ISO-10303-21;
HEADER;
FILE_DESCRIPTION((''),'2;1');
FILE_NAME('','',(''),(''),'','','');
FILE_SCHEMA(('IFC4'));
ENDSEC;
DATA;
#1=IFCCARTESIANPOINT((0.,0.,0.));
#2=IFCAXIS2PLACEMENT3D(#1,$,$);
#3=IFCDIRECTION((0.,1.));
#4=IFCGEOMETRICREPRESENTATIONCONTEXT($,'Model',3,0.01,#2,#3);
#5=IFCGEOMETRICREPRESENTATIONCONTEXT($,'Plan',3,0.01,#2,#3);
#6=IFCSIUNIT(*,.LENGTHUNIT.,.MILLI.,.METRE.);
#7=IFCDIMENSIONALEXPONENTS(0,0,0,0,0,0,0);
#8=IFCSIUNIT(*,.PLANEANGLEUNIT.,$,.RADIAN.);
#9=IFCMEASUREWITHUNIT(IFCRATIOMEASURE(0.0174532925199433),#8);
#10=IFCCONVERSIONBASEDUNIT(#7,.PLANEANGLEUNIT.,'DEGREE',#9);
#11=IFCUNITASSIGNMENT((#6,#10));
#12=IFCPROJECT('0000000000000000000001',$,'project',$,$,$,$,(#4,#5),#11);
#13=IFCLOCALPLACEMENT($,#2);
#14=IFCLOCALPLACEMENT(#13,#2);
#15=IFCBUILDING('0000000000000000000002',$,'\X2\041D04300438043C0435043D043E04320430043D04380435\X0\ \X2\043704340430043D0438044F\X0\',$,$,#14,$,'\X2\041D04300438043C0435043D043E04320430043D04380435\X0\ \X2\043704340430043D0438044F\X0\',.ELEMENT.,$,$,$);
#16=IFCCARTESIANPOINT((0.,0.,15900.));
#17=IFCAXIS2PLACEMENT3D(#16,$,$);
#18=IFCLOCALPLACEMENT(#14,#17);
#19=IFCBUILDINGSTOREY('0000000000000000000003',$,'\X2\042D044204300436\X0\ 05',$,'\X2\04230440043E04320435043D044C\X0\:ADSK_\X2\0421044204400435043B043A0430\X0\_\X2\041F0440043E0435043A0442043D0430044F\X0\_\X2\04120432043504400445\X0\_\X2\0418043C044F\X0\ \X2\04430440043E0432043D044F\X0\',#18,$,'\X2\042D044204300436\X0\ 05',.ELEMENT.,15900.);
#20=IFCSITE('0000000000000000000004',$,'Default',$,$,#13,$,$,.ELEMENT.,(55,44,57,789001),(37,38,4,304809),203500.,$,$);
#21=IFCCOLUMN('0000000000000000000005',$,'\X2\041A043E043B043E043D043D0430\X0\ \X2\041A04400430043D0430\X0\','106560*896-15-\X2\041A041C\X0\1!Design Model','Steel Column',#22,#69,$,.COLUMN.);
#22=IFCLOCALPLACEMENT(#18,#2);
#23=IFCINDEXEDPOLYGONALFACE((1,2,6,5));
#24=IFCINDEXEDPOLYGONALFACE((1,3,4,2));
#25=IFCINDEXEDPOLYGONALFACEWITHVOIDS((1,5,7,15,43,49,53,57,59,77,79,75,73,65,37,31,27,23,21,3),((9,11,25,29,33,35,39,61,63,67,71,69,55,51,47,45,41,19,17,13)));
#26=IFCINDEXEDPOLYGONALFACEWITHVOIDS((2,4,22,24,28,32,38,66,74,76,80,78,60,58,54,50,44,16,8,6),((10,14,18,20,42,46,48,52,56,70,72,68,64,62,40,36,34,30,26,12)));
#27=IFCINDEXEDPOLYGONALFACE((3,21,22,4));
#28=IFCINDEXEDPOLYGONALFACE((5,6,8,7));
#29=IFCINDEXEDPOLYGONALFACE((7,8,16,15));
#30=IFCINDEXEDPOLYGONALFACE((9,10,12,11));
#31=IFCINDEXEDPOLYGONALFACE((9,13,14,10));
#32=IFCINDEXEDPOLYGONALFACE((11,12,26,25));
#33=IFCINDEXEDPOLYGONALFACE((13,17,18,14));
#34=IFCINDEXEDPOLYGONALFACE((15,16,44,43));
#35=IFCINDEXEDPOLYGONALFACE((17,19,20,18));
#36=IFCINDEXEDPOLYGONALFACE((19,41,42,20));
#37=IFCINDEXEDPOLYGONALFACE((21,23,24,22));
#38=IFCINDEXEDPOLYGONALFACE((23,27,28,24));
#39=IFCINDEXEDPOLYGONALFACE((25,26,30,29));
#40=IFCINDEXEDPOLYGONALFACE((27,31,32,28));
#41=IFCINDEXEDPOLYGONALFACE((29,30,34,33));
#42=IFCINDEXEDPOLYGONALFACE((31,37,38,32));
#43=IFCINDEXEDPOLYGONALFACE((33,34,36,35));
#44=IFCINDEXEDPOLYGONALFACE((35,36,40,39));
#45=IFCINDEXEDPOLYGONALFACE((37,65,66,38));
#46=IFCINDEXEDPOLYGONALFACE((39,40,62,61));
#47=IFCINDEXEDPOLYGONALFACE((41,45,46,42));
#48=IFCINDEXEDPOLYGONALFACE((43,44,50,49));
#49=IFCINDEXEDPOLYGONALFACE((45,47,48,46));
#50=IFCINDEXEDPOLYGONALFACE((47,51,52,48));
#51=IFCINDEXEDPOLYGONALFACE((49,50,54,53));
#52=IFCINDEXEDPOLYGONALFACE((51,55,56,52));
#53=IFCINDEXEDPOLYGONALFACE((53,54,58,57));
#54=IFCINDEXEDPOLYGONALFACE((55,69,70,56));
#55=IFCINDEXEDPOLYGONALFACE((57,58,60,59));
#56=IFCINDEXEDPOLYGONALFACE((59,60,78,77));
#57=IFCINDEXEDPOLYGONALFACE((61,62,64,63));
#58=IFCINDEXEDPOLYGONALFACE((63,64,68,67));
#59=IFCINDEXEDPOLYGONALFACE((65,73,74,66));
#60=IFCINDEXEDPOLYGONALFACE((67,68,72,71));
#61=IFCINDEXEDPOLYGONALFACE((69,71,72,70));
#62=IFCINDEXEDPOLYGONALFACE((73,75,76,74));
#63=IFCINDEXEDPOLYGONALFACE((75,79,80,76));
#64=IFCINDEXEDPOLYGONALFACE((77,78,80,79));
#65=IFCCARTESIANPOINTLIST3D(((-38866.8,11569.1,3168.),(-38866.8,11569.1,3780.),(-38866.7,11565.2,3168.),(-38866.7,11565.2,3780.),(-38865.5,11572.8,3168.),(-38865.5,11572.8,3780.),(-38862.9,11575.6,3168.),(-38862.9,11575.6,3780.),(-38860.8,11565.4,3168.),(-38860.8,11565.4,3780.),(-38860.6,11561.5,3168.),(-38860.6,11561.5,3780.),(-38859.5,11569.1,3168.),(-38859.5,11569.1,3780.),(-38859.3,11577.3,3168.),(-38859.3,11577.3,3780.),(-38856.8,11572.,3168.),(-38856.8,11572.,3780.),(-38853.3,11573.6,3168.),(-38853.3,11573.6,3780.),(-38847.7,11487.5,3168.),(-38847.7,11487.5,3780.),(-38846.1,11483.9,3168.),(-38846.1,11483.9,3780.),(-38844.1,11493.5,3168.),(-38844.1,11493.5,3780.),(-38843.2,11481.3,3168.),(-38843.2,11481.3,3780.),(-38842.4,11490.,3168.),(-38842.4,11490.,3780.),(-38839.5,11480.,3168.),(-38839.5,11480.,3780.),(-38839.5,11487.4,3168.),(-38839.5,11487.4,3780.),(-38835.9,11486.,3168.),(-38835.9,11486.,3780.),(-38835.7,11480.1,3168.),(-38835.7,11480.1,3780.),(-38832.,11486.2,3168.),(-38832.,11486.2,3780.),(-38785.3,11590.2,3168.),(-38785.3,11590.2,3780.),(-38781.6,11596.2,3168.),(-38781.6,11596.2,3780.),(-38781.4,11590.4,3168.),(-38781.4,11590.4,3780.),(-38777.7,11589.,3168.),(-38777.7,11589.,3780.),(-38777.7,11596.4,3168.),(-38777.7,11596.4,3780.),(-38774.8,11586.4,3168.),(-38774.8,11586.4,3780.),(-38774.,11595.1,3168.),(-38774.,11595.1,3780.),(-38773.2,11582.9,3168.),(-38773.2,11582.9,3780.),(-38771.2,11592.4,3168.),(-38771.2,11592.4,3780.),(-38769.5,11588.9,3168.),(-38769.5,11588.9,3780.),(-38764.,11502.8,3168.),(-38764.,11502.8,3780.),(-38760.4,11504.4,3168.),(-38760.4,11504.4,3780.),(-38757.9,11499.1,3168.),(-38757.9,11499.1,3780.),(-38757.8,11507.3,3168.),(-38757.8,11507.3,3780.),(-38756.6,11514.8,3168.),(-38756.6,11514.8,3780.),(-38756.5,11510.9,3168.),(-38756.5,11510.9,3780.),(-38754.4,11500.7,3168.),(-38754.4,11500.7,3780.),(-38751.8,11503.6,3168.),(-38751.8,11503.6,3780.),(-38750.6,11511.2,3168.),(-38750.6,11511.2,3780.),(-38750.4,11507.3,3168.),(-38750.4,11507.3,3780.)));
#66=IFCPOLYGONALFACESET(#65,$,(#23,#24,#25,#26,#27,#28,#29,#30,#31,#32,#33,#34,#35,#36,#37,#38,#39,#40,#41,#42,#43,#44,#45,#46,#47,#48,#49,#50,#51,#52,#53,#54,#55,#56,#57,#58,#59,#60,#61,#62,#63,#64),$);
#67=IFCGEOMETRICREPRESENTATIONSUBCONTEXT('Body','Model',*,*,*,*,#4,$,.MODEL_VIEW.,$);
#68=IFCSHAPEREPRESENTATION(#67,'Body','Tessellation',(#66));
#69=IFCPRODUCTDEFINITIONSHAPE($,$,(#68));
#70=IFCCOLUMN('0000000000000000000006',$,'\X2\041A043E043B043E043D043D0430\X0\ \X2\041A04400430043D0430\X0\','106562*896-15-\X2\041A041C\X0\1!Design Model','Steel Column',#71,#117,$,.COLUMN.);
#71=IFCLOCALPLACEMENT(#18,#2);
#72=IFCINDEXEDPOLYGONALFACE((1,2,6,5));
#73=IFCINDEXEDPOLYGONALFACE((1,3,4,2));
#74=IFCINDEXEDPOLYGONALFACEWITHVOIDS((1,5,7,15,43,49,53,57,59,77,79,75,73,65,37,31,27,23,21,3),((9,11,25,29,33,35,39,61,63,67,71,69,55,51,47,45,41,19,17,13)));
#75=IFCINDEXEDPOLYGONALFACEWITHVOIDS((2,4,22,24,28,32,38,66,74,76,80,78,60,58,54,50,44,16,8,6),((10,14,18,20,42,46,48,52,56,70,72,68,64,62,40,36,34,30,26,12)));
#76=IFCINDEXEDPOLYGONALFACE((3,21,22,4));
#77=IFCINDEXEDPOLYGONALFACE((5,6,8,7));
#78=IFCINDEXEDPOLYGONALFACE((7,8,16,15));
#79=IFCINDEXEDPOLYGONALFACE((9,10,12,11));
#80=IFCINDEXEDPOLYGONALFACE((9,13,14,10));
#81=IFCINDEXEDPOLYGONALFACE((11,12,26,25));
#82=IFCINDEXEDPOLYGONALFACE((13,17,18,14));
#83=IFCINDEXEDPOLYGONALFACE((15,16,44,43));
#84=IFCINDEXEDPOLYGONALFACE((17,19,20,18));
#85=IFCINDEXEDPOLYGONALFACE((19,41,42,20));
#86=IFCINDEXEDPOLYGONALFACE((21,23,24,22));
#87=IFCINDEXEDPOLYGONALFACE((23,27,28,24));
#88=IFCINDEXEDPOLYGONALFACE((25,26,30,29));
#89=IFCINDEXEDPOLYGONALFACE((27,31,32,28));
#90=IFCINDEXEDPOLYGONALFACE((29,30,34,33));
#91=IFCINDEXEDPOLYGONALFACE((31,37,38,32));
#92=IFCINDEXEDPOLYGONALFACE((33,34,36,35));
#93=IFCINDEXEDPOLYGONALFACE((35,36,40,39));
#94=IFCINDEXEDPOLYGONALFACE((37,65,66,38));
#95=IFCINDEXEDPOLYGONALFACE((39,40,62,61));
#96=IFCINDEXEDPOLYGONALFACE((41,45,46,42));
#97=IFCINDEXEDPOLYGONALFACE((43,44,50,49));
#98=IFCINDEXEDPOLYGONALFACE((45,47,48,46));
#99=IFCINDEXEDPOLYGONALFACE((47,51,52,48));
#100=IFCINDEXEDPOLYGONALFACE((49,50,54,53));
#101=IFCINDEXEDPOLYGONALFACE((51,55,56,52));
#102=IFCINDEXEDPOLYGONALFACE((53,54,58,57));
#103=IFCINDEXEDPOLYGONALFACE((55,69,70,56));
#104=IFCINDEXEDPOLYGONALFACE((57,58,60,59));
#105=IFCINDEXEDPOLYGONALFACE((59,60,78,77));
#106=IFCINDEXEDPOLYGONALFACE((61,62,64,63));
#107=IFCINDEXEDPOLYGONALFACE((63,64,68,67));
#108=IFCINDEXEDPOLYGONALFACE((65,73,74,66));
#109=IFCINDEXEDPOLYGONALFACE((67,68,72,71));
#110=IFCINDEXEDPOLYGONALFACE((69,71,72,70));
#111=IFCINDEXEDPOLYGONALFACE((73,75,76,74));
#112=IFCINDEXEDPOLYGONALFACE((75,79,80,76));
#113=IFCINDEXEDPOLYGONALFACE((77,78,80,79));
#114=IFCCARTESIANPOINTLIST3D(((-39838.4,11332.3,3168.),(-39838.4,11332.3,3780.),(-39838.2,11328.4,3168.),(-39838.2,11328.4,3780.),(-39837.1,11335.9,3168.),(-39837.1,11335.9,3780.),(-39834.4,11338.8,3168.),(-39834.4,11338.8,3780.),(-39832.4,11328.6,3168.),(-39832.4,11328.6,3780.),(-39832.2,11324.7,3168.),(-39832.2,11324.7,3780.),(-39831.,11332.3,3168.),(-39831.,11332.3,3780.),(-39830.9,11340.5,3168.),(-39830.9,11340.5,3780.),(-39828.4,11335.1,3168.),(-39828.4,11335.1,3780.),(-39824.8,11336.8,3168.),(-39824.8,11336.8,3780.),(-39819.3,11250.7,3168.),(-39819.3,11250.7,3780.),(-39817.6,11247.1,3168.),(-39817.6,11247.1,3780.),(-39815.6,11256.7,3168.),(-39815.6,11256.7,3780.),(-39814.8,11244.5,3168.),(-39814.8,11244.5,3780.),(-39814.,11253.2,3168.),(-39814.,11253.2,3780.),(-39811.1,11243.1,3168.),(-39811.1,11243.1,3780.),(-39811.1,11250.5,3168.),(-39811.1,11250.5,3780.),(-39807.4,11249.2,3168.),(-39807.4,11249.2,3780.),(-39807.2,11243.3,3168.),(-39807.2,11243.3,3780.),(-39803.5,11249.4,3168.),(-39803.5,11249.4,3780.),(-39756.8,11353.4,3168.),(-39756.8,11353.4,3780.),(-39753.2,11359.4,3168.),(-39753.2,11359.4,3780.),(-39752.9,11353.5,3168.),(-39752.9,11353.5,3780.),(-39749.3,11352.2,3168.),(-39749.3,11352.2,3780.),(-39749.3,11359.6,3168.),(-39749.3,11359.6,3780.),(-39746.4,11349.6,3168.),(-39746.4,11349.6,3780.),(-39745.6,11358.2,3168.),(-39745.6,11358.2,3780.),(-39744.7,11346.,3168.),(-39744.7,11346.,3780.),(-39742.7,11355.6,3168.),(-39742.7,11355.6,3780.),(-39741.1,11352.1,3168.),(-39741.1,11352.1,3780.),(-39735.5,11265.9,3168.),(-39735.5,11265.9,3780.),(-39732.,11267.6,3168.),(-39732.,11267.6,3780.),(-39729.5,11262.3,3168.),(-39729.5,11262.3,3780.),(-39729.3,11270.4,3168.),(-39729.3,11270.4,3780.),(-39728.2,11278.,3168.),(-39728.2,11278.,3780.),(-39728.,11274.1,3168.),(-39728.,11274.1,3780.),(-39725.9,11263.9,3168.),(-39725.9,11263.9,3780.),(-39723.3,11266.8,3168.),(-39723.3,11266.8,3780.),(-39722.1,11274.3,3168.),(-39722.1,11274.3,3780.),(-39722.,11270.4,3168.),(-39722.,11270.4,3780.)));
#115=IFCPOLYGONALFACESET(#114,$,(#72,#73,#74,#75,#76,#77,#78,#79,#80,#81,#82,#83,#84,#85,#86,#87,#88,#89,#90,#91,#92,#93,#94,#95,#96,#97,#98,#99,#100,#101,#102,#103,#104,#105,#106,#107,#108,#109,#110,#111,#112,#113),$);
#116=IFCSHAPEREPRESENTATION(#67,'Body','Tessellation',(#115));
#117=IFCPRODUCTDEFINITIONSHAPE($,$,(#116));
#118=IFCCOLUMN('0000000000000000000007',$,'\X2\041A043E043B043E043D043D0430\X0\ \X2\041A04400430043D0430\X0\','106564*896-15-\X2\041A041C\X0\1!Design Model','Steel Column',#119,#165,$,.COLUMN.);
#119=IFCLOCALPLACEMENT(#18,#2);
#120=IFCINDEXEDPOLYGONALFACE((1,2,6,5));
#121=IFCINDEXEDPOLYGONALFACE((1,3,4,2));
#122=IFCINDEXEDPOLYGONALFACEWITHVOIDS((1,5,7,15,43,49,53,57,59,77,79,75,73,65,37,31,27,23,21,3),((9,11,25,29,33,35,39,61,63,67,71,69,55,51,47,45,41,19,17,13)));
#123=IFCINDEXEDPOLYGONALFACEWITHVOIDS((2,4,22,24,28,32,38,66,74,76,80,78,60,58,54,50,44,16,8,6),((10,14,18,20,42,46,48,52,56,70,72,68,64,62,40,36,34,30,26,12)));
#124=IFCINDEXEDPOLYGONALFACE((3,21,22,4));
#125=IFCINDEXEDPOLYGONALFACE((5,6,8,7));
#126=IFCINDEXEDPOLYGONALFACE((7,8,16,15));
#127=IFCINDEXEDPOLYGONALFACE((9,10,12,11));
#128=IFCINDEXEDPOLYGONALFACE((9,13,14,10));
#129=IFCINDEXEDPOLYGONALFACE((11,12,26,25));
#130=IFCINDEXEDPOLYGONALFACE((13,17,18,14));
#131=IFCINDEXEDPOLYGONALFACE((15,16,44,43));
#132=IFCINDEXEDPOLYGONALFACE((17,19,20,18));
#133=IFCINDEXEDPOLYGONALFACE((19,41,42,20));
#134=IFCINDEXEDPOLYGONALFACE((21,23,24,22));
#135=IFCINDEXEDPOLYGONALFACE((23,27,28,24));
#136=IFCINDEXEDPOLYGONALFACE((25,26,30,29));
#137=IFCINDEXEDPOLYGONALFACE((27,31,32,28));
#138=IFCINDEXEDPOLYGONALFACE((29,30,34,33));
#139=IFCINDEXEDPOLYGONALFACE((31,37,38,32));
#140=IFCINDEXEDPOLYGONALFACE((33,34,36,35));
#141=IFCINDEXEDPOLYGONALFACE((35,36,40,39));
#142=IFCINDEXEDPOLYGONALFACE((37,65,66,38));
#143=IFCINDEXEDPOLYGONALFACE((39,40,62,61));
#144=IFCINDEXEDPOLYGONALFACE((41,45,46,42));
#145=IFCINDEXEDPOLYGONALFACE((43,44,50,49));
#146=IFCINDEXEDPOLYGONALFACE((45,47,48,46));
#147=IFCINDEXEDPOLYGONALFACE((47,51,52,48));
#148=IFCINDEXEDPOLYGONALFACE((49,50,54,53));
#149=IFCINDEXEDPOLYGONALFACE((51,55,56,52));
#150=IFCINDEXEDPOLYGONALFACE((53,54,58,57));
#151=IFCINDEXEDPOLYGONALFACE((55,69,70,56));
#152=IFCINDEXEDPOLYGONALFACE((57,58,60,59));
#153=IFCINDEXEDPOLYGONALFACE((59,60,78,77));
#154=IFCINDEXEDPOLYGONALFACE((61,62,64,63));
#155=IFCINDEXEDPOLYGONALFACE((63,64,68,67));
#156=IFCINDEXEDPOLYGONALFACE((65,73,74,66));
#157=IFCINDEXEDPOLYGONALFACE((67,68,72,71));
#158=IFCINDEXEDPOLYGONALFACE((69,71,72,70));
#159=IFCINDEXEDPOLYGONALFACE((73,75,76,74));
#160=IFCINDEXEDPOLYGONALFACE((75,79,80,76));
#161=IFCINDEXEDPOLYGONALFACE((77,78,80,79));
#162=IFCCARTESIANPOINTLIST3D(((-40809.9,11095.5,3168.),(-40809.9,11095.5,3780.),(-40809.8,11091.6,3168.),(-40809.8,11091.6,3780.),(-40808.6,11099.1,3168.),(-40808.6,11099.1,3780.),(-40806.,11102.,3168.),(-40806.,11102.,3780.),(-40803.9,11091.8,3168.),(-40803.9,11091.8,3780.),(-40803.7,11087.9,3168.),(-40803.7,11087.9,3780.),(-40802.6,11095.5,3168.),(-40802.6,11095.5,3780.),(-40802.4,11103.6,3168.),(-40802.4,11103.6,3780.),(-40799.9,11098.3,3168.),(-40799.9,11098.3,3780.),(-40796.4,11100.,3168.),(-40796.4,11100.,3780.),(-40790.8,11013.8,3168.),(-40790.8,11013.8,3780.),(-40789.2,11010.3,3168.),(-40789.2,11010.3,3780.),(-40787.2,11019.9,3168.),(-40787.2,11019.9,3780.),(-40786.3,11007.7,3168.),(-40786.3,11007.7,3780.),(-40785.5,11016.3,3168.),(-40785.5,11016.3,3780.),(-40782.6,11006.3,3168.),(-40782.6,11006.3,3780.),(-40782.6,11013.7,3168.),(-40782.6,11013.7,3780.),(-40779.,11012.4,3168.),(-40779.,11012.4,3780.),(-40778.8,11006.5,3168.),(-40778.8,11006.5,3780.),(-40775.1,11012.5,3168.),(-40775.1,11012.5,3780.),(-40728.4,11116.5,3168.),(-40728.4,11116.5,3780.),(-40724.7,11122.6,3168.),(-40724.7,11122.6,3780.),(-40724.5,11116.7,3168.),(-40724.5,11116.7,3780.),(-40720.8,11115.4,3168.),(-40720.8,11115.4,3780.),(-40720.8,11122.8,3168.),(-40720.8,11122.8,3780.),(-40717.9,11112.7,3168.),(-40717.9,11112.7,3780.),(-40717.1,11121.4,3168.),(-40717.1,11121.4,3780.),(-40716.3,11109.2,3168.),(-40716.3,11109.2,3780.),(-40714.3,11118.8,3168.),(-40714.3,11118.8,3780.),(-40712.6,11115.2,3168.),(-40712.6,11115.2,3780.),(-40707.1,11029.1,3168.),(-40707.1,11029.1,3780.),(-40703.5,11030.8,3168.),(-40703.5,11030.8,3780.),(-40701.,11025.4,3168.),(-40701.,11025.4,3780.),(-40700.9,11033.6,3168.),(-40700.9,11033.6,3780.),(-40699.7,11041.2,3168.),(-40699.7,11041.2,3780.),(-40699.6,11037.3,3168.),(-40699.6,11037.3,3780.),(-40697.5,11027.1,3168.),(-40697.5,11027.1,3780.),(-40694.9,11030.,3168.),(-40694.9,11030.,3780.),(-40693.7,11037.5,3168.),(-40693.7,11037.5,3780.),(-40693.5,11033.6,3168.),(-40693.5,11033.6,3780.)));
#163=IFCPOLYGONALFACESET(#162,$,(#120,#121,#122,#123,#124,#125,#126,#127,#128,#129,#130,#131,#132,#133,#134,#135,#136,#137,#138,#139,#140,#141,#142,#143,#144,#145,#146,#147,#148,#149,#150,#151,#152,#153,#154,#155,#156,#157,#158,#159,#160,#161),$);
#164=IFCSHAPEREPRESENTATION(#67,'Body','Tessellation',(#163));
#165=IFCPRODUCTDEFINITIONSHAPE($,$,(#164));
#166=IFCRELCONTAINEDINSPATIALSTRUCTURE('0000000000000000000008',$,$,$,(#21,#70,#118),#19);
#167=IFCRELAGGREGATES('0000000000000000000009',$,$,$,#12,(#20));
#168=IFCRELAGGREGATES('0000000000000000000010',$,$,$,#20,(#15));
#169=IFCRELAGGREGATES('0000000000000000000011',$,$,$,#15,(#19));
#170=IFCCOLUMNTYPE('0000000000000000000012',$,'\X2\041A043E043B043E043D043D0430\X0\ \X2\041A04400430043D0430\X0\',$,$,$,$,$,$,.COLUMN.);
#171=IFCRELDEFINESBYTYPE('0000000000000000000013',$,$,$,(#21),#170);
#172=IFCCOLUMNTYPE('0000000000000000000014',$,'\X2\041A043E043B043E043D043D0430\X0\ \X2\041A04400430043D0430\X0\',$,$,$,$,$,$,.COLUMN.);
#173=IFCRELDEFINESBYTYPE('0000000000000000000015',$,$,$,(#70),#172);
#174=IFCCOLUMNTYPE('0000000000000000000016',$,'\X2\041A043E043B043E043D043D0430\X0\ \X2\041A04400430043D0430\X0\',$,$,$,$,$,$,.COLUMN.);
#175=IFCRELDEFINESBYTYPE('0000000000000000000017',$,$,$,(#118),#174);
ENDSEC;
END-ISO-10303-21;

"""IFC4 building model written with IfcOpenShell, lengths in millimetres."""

from ifc_helpers import new_model, entity, si_unit, converted_unit, direction, frame, origin, place, context, subcontext, project, spatial, indexed_curve, outline, extrude, type_object, element, save


model = new_model("IFC4")

# Units and contexts
model_context = context("Model", 3, precision=0.01, world=origin(), true_north=direction((0.0, 1.0)))
plan_context = context("Plan", 3, precision=0.01, world=origin(), true_north=direction((0.0, 1.0)))
body_context = subcontext(model_context, "Body", "Model", "MODEL_VIEW")
ifc_project = project(units=[si_unit("LENGTHUNIT", "METRE", prefix="MILLI"), converted_unit("PLANEANGLEUNIT", "DEGREE", entity("IfcRatioMeasure", 0.0174532925199433), si_unit("PLANEANGLEUNIT", "RADIAN"), dimensions=[0, 0, 0, 0, 0, 0, 0])], contexts=[model_context, plan_context])

# Site, building, storey
site_placement = place(None, origin())
site = spatial("IfcSite", under=ifc_project, at=site_placement, Name="Default", CompositionType="ELEMENT", RefLatitude=(55, 44, 57, 789001), RefLongitude=(37, 38, 4, 304809), RefElevation=203500.0)
building_placement = place(site_placement, origin())
building = spatial("IfcBuilding", under=site, at=building_placement, Name="Наименование здания", LongName="Наименование здания", CompositionType="ELEMENT")
storey_placement = place(building_placement, frame((0.0, 0.0, 15900.0)))
storey = spatial("IfcBuildingStorey", under=building, at=storey_placement, Name="Этаж 05", ObjectType="Уровень:ADSK_Стрелка_Проектная_Вверх_Имя уровня", LongName="Этаж 05", CompositionType="ELEMENT", Elevation=15900.0)

# Columns
placement = place(storey_placement, origin())
column_type_1 = type_object("IfcColumnType", Name="Колонна Крана", PredefinedType="COLUMN")
element("IfcColumn", 1, at=placement, inside=storey, type_object=column_type_1, Name="Колонна Крана", Description="106560*896-15-КМ1!Design Model", ObjectType="Steel Column", PredefinedType="COLUMN", context=body_context, shape_type="SweptSolid", body=[
    extrude(outline(indexed_curve([(29.5, -56.8), (33.4, -56.8), (37.0, -55.3), (39.7, -52.6), (41.2, -49.0), (56.8, 29.5), (56.8, 33.4), (55.3, 37.0), (52.6, 39.7), (49.0, 41.2), (-29.5, 56.8), (-33.4, 56.8), (-37.0, 55.3), (-39.7, 52.6), (-41.2, 49.0), (-56.8, -29.5), (-56.8, -33.4), (-55.3, -37.0), (-52.6, -39.7), (-49.0, -41.2), (29.5, -56.8)], self_intersect=False), holes=[indexed_curve([(-43.1, -37.3), (-46.7, -35.8), (-49.5, -33.1), (-51.0, -29.5), (-51.0, -25.5), (-37.3, 43.1), (-35.8, 46.7), (-33.1, 49.5), (-29.5, 51.0), (-25.5, 51.0), (43.1, 37.3), (46.7, 35.8), (49.5, 33.1), (51.0, 29.5), (51.0, 25.5), (37.3, -43.1), (35.8, -46.7), (33.1, -49.5), (29.5, -51.0), (25.5, -51.0), (-43.1, -37.3)], self_intersect=False)]), frame((-38808.6, 11538.2, 3168.0), z_axis=(0.0, 0.0, 1.0), x_axis=(0.906681, 0.421816, 0.0)), (0.0, 0.0, 1.0), 612.0),
])
column_type_2 = type_object("IfcColumnType", Name="Колонна Крана", PredefinedType="COLUMN")
element("IfcColumn", 2, at=placement, inside=storey, type_object=column_type_2, Name="Колонна Крана", Description="106562*896-15-КМ1!Design Model", ObjectType="Steel Column", PredefinedType="COLUMN", context=body_context, shape_type="SweptSolid", body=[
    extrude(outline(indexed_curve([(29.5, -56.8), (33.4, -56.8), (37.0, -55.3), (39.7, -52.6), (41.2, -49.0), (56.8, 29.5), (56.8, 33.4), (55.3, 37.0), (52.6, 39.7), (49.0, 41.2), (-29.5, 56.8), (-33.4, 56.8), (-37.0, 55.3), (-39.7, 52.6), (-41.2, 49.0), (-56.8, -29.5), (-56.8, -33.4), (-55.3, -37.0), (-52.6, -39.7), (-49.0, -41.2), (29.5, -56.8)], self_intersect=False), holes=[indexed_curve([(-43.1, -37.3), (-46.7, -35.8), (-49.5, -33.1), (-51.0, -29.5), (-51.0, -25.5), (-37.3, 43.1), (-35.8, 46.7), (-33.1, 49.5), (-29.5, 51.0), (-25.5, 51.0), (43.1, 37.3), (46.7, 35.8), (49.5, 33.1), (51.0, 29.5), (51.0, 25.5), (37.3, -43.1), (35.8, -46.7), (33.1, -49.5), (29.5, -51.0), (25.5, -51.0), (-43.1, -37.3)], self_intersect=False)]), frame((-39780.2, 11301.4, 3168.0), z_axis=(0.0, 0.0, 1.0), x_axis=(0.906681, 0.421816, 0.0)), (0.0, 0.0, 1.0), 612.0),
])
column_type_3 = type_object("IfcColumnType", Name="Колонна Крана", PredefinedType="COLUMN")
element("IfcColumn", 3, at=placement, inside=storey, type_object=column_type_3, Name="Колонна Крана", Description="106564*896-15-КМ1!Design Model", ObjectType="Steel Column", PredefinedType="COLUMN", context=body_context, shape_type="SweptSolid", body=[
    extrude(outline(indexed_curve([(29.5, -56.8), (33.4, -56.8), (37.0, -55.3), (39.7, -52.6), (41.2, -49.0), (56.8, 29.5), (56.8, 33.4), (55.3, 37.0), (52.6, 39.7), (49.0, 41.2), (-29.5, 56.8), (-33.4, 56.8), (-37.0, 55.3), (-39.7, 52.6), (-41.2, 49.0), (-56.8, -29.5), (-56.8, -33.4), (-55.3, -37.0), (-52.6, -39.7), (-49.0, -41.2), (29.5, -56.8)], self_intersect=False), holes=[indexed_curve([(-43.1, -37.3), (-46.7, -35.8), (-49.5, -33.1), (-51.0, -29.5), (-51.0, -25.5), (-37.3, 43.1), (-35.8, 46.7), (-33.1, 49.5), (-29.5, 51.0), (-25.5, 51.0), (43.1, 37.3), (46.7, 35.8), (49.5, 33.1), (51.0, 29.5), (51.0, 25.5), (37.3, -43.1), (35.8, -46.7), (33.1, -49.5), (29.5, -51.0), (25.5, -51.0), (-43.1, -37.3)], self_intersect=False)]), frame((-40751.7, 11064.5, 3168.0), z_axis=(0.0, 0.0, 1.0), x_axis=(0.906681, 0.421816, 0.0)), (0.0, 0.0, 1.0), 612.0),
])

save(model, "model.ifc")
